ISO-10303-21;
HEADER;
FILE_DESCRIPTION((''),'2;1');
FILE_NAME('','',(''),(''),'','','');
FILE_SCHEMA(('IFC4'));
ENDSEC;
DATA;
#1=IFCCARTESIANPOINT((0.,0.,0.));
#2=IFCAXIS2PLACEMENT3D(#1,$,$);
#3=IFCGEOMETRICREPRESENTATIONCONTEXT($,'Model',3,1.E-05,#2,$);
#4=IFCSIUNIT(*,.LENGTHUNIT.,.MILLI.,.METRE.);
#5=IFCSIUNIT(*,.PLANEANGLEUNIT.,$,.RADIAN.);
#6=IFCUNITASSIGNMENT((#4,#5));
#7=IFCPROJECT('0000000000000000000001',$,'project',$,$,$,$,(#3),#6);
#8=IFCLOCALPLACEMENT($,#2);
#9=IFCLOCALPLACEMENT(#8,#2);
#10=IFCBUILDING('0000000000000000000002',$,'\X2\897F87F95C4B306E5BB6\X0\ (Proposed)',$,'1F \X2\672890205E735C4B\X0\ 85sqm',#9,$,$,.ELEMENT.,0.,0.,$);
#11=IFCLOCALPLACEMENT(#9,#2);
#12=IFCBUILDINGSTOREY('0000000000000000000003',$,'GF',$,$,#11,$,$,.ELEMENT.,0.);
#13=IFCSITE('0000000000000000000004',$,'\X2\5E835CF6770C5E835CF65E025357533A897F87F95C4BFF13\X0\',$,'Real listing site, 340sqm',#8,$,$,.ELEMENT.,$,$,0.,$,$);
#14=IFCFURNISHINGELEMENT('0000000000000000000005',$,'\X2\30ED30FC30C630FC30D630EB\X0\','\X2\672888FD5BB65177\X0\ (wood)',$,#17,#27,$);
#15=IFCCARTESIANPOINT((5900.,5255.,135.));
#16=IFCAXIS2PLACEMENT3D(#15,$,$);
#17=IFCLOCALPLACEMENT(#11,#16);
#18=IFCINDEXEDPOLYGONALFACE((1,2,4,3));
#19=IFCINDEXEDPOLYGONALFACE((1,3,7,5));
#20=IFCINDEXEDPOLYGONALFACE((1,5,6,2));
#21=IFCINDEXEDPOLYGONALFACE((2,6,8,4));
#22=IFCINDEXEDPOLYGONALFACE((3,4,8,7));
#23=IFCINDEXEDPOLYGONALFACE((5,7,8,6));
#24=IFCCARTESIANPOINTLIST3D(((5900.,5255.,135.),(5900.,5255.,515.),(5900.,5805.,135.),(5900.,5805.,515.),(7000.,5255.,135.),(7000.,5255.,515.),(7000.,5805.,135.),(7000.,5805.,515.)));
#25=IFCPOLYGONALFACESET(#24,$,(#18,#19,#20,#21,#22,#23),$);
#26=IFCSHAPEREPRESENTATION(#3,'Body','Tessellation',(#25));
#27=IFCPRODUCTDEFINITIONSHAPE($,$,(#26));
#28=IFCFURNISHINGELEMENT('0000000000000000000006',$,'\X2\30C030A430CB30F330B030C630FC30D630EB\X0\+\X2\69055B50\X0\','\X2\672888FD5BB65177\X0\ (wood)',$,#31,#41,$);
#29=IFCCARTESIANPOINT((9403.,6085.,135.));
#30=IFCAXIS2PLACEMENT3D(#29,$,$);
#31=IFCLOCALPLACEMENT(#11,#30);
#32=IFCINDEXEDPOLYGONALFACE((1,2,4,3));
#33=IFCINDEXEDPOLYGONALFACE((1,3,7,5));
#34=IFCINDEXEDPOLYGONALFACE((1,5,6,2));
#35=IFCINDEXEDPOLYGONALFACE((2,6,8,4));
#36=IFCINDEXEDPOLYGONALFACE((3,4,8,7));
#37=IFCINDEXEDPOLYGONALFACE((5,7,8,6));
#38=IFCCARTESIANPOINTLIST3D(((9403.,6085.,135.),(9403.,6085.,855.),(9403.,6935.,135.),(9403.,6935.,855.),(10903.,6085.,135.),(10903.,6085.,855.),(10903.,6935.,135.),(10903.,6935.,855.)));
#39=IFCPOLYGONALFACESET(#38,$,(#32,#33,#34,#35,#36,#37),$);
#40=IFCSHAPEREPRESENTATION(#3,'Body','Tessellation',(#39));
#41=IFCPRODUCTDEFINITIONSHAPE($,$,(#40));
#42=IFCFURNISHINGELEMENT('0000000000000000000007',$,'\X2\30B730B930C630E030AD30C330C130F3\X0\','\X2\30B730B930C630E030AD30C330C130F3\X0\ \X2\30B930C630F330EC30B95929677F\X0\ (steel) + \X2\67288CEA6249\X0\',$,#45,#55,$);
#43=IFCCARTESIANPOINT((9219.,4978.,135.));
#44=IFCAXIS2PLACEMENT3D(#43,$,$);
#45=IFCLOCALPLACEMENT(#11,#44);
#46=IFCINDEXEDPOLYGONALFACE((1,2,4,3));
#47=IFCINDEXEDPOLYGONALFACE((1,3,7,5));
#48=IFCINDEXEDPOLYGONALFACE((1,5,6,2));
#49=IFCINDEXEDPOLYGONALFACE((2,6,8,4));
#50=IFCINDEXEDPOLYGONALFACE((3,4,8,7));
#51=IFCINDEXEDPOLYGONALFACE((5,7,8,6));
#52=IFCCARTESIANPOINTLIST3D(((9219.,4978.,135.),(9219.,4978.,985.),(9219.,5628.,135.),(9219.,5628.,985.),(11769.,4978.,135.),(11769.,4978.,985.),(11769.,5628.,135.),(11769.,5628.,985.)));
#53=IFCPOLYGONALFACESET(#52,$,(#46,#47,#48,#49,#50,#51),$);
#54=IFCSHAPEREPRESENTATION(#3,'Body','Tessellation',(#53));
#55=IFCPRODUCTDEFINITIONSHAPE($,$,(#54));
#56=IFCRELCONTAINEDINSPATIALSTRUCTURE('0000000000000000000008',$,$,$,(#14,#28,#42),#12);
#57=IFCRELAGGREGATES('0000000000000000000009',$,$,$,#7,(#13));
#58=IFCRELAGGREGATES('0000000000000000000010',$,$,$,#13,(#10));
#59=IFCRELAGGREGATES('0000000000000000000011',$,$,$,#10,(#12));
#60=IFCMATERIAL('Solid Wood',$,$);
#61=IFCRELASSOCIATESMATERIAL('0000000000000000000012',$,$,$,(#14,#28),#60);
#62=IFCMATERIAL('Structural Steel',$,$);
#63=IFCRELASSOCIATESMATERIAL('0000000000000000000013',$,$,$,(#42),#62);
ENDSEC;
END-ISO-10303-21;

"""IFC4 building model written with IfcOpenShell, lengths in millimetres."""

from ifc_helpers import new_model, si_unit, frame, frame_2d, origin, place, context, project, spatial, rectangle, extrude, material, element, save


model = new_model("IFC4")

# Units and contexts
model_context = context("Model", 3, precision=1e-05, world=origin())
ifc_project = project(units=[si_unit("LENGTHUNIT", "METRE", prefix="MILLI"), si_unit("PLANEANGLEUNIT", "RADIAN")], contexts=[model_context])

# Site, building, storey
site_placement = place(None, origin())
site = spatial("IfcSite", under=ifc_project, at=site_placement, Name="広島県広島市南区西蟹屋３", ObjectType="Real listing site, 340sqm", CompositionType="ELEMENT", RefElevation=0.0)
building_placement = place(site_placement, origin())
building = spatial("IfcBuilding", under=site, at=building_placement, Name="西蟹屋の家 (Proposed)", ObjectType="1F 木造平屋 85sqm", CompositionType="ELEMENT", ElevationOfRefHeight=0.0, ElevationOfTerrain=0.0)
storey_placement = place(building_placement, origin())
storey = spatial("IfcBuildingStorey", under=building, at=storey_placement, Name="GF", CompositionType="ELEMENT", Elevation=0.0)

# Shared definitions
ifc_material_1 = material(Name="Solid Wood")

# Shared definitions
ifc_material_2 = material(Name="Structural Steel")

# Furnishing elements
furnishing_1_placement = place(storey_placement, frame((5900.0, 5255.0, 135.0)))
element("IfcFurnishingElement", 1, at=furnishing_1_placement, inside=storey, material=ifc_material_1, Name="ローテーブル", Description="木製家具 (wood)", context=model_context, shape_type="SweptSolid", body=[
    extrude(rectangle(XDim=1100.0, YDim=550.0, at=frame_2d((550.0, 275.0))), frame((5900.0, 5255.0, 135.0)), (0.0, 0.0, 1.0), 380.0),
])
furnishing_2_placement = place(storey_placement, frame((9403.0, 6085.0, 135.0)))
element("IfcFurnishingElement", 2, at=furnishing_2_placement, inside=storey, material=ifc_material_1, Name="ダイニングテーブル+椅子", Description="木製家具 (wood)", context=model_context, shape_type="SweptSolid", body=[
    extrude(rectangle(XDim=1500.0, YDim=850.0, at=frame_2d((750.0, 425.0))), frame((9403.0, 6085.0, 135.0)), (0.0, 0.0, 1.0), 720.0),
])
furnishing_3_placement = place(storey_placement, frame((9219.0, 4978.0, 135.0)))
element("IfcFurnishingElement", 3, at=furnishing_3_placement, inside=storey, material=ifc_material_2, Name="システムキッチン", Description="システムキッチン ステンレス天板 (steel) + 木質扉", context=model_context, shape_type="SweptSolid", body=[
    extrude(rectangle(XDim=2550.0, YDim=650.0, at=frame_2d((1275.0, 325.0))), frame((9219.0, 4978.0, 135.0)), (0.0, 0.0, 1.0), 850.0),
])

save(model, "model.ifc")
